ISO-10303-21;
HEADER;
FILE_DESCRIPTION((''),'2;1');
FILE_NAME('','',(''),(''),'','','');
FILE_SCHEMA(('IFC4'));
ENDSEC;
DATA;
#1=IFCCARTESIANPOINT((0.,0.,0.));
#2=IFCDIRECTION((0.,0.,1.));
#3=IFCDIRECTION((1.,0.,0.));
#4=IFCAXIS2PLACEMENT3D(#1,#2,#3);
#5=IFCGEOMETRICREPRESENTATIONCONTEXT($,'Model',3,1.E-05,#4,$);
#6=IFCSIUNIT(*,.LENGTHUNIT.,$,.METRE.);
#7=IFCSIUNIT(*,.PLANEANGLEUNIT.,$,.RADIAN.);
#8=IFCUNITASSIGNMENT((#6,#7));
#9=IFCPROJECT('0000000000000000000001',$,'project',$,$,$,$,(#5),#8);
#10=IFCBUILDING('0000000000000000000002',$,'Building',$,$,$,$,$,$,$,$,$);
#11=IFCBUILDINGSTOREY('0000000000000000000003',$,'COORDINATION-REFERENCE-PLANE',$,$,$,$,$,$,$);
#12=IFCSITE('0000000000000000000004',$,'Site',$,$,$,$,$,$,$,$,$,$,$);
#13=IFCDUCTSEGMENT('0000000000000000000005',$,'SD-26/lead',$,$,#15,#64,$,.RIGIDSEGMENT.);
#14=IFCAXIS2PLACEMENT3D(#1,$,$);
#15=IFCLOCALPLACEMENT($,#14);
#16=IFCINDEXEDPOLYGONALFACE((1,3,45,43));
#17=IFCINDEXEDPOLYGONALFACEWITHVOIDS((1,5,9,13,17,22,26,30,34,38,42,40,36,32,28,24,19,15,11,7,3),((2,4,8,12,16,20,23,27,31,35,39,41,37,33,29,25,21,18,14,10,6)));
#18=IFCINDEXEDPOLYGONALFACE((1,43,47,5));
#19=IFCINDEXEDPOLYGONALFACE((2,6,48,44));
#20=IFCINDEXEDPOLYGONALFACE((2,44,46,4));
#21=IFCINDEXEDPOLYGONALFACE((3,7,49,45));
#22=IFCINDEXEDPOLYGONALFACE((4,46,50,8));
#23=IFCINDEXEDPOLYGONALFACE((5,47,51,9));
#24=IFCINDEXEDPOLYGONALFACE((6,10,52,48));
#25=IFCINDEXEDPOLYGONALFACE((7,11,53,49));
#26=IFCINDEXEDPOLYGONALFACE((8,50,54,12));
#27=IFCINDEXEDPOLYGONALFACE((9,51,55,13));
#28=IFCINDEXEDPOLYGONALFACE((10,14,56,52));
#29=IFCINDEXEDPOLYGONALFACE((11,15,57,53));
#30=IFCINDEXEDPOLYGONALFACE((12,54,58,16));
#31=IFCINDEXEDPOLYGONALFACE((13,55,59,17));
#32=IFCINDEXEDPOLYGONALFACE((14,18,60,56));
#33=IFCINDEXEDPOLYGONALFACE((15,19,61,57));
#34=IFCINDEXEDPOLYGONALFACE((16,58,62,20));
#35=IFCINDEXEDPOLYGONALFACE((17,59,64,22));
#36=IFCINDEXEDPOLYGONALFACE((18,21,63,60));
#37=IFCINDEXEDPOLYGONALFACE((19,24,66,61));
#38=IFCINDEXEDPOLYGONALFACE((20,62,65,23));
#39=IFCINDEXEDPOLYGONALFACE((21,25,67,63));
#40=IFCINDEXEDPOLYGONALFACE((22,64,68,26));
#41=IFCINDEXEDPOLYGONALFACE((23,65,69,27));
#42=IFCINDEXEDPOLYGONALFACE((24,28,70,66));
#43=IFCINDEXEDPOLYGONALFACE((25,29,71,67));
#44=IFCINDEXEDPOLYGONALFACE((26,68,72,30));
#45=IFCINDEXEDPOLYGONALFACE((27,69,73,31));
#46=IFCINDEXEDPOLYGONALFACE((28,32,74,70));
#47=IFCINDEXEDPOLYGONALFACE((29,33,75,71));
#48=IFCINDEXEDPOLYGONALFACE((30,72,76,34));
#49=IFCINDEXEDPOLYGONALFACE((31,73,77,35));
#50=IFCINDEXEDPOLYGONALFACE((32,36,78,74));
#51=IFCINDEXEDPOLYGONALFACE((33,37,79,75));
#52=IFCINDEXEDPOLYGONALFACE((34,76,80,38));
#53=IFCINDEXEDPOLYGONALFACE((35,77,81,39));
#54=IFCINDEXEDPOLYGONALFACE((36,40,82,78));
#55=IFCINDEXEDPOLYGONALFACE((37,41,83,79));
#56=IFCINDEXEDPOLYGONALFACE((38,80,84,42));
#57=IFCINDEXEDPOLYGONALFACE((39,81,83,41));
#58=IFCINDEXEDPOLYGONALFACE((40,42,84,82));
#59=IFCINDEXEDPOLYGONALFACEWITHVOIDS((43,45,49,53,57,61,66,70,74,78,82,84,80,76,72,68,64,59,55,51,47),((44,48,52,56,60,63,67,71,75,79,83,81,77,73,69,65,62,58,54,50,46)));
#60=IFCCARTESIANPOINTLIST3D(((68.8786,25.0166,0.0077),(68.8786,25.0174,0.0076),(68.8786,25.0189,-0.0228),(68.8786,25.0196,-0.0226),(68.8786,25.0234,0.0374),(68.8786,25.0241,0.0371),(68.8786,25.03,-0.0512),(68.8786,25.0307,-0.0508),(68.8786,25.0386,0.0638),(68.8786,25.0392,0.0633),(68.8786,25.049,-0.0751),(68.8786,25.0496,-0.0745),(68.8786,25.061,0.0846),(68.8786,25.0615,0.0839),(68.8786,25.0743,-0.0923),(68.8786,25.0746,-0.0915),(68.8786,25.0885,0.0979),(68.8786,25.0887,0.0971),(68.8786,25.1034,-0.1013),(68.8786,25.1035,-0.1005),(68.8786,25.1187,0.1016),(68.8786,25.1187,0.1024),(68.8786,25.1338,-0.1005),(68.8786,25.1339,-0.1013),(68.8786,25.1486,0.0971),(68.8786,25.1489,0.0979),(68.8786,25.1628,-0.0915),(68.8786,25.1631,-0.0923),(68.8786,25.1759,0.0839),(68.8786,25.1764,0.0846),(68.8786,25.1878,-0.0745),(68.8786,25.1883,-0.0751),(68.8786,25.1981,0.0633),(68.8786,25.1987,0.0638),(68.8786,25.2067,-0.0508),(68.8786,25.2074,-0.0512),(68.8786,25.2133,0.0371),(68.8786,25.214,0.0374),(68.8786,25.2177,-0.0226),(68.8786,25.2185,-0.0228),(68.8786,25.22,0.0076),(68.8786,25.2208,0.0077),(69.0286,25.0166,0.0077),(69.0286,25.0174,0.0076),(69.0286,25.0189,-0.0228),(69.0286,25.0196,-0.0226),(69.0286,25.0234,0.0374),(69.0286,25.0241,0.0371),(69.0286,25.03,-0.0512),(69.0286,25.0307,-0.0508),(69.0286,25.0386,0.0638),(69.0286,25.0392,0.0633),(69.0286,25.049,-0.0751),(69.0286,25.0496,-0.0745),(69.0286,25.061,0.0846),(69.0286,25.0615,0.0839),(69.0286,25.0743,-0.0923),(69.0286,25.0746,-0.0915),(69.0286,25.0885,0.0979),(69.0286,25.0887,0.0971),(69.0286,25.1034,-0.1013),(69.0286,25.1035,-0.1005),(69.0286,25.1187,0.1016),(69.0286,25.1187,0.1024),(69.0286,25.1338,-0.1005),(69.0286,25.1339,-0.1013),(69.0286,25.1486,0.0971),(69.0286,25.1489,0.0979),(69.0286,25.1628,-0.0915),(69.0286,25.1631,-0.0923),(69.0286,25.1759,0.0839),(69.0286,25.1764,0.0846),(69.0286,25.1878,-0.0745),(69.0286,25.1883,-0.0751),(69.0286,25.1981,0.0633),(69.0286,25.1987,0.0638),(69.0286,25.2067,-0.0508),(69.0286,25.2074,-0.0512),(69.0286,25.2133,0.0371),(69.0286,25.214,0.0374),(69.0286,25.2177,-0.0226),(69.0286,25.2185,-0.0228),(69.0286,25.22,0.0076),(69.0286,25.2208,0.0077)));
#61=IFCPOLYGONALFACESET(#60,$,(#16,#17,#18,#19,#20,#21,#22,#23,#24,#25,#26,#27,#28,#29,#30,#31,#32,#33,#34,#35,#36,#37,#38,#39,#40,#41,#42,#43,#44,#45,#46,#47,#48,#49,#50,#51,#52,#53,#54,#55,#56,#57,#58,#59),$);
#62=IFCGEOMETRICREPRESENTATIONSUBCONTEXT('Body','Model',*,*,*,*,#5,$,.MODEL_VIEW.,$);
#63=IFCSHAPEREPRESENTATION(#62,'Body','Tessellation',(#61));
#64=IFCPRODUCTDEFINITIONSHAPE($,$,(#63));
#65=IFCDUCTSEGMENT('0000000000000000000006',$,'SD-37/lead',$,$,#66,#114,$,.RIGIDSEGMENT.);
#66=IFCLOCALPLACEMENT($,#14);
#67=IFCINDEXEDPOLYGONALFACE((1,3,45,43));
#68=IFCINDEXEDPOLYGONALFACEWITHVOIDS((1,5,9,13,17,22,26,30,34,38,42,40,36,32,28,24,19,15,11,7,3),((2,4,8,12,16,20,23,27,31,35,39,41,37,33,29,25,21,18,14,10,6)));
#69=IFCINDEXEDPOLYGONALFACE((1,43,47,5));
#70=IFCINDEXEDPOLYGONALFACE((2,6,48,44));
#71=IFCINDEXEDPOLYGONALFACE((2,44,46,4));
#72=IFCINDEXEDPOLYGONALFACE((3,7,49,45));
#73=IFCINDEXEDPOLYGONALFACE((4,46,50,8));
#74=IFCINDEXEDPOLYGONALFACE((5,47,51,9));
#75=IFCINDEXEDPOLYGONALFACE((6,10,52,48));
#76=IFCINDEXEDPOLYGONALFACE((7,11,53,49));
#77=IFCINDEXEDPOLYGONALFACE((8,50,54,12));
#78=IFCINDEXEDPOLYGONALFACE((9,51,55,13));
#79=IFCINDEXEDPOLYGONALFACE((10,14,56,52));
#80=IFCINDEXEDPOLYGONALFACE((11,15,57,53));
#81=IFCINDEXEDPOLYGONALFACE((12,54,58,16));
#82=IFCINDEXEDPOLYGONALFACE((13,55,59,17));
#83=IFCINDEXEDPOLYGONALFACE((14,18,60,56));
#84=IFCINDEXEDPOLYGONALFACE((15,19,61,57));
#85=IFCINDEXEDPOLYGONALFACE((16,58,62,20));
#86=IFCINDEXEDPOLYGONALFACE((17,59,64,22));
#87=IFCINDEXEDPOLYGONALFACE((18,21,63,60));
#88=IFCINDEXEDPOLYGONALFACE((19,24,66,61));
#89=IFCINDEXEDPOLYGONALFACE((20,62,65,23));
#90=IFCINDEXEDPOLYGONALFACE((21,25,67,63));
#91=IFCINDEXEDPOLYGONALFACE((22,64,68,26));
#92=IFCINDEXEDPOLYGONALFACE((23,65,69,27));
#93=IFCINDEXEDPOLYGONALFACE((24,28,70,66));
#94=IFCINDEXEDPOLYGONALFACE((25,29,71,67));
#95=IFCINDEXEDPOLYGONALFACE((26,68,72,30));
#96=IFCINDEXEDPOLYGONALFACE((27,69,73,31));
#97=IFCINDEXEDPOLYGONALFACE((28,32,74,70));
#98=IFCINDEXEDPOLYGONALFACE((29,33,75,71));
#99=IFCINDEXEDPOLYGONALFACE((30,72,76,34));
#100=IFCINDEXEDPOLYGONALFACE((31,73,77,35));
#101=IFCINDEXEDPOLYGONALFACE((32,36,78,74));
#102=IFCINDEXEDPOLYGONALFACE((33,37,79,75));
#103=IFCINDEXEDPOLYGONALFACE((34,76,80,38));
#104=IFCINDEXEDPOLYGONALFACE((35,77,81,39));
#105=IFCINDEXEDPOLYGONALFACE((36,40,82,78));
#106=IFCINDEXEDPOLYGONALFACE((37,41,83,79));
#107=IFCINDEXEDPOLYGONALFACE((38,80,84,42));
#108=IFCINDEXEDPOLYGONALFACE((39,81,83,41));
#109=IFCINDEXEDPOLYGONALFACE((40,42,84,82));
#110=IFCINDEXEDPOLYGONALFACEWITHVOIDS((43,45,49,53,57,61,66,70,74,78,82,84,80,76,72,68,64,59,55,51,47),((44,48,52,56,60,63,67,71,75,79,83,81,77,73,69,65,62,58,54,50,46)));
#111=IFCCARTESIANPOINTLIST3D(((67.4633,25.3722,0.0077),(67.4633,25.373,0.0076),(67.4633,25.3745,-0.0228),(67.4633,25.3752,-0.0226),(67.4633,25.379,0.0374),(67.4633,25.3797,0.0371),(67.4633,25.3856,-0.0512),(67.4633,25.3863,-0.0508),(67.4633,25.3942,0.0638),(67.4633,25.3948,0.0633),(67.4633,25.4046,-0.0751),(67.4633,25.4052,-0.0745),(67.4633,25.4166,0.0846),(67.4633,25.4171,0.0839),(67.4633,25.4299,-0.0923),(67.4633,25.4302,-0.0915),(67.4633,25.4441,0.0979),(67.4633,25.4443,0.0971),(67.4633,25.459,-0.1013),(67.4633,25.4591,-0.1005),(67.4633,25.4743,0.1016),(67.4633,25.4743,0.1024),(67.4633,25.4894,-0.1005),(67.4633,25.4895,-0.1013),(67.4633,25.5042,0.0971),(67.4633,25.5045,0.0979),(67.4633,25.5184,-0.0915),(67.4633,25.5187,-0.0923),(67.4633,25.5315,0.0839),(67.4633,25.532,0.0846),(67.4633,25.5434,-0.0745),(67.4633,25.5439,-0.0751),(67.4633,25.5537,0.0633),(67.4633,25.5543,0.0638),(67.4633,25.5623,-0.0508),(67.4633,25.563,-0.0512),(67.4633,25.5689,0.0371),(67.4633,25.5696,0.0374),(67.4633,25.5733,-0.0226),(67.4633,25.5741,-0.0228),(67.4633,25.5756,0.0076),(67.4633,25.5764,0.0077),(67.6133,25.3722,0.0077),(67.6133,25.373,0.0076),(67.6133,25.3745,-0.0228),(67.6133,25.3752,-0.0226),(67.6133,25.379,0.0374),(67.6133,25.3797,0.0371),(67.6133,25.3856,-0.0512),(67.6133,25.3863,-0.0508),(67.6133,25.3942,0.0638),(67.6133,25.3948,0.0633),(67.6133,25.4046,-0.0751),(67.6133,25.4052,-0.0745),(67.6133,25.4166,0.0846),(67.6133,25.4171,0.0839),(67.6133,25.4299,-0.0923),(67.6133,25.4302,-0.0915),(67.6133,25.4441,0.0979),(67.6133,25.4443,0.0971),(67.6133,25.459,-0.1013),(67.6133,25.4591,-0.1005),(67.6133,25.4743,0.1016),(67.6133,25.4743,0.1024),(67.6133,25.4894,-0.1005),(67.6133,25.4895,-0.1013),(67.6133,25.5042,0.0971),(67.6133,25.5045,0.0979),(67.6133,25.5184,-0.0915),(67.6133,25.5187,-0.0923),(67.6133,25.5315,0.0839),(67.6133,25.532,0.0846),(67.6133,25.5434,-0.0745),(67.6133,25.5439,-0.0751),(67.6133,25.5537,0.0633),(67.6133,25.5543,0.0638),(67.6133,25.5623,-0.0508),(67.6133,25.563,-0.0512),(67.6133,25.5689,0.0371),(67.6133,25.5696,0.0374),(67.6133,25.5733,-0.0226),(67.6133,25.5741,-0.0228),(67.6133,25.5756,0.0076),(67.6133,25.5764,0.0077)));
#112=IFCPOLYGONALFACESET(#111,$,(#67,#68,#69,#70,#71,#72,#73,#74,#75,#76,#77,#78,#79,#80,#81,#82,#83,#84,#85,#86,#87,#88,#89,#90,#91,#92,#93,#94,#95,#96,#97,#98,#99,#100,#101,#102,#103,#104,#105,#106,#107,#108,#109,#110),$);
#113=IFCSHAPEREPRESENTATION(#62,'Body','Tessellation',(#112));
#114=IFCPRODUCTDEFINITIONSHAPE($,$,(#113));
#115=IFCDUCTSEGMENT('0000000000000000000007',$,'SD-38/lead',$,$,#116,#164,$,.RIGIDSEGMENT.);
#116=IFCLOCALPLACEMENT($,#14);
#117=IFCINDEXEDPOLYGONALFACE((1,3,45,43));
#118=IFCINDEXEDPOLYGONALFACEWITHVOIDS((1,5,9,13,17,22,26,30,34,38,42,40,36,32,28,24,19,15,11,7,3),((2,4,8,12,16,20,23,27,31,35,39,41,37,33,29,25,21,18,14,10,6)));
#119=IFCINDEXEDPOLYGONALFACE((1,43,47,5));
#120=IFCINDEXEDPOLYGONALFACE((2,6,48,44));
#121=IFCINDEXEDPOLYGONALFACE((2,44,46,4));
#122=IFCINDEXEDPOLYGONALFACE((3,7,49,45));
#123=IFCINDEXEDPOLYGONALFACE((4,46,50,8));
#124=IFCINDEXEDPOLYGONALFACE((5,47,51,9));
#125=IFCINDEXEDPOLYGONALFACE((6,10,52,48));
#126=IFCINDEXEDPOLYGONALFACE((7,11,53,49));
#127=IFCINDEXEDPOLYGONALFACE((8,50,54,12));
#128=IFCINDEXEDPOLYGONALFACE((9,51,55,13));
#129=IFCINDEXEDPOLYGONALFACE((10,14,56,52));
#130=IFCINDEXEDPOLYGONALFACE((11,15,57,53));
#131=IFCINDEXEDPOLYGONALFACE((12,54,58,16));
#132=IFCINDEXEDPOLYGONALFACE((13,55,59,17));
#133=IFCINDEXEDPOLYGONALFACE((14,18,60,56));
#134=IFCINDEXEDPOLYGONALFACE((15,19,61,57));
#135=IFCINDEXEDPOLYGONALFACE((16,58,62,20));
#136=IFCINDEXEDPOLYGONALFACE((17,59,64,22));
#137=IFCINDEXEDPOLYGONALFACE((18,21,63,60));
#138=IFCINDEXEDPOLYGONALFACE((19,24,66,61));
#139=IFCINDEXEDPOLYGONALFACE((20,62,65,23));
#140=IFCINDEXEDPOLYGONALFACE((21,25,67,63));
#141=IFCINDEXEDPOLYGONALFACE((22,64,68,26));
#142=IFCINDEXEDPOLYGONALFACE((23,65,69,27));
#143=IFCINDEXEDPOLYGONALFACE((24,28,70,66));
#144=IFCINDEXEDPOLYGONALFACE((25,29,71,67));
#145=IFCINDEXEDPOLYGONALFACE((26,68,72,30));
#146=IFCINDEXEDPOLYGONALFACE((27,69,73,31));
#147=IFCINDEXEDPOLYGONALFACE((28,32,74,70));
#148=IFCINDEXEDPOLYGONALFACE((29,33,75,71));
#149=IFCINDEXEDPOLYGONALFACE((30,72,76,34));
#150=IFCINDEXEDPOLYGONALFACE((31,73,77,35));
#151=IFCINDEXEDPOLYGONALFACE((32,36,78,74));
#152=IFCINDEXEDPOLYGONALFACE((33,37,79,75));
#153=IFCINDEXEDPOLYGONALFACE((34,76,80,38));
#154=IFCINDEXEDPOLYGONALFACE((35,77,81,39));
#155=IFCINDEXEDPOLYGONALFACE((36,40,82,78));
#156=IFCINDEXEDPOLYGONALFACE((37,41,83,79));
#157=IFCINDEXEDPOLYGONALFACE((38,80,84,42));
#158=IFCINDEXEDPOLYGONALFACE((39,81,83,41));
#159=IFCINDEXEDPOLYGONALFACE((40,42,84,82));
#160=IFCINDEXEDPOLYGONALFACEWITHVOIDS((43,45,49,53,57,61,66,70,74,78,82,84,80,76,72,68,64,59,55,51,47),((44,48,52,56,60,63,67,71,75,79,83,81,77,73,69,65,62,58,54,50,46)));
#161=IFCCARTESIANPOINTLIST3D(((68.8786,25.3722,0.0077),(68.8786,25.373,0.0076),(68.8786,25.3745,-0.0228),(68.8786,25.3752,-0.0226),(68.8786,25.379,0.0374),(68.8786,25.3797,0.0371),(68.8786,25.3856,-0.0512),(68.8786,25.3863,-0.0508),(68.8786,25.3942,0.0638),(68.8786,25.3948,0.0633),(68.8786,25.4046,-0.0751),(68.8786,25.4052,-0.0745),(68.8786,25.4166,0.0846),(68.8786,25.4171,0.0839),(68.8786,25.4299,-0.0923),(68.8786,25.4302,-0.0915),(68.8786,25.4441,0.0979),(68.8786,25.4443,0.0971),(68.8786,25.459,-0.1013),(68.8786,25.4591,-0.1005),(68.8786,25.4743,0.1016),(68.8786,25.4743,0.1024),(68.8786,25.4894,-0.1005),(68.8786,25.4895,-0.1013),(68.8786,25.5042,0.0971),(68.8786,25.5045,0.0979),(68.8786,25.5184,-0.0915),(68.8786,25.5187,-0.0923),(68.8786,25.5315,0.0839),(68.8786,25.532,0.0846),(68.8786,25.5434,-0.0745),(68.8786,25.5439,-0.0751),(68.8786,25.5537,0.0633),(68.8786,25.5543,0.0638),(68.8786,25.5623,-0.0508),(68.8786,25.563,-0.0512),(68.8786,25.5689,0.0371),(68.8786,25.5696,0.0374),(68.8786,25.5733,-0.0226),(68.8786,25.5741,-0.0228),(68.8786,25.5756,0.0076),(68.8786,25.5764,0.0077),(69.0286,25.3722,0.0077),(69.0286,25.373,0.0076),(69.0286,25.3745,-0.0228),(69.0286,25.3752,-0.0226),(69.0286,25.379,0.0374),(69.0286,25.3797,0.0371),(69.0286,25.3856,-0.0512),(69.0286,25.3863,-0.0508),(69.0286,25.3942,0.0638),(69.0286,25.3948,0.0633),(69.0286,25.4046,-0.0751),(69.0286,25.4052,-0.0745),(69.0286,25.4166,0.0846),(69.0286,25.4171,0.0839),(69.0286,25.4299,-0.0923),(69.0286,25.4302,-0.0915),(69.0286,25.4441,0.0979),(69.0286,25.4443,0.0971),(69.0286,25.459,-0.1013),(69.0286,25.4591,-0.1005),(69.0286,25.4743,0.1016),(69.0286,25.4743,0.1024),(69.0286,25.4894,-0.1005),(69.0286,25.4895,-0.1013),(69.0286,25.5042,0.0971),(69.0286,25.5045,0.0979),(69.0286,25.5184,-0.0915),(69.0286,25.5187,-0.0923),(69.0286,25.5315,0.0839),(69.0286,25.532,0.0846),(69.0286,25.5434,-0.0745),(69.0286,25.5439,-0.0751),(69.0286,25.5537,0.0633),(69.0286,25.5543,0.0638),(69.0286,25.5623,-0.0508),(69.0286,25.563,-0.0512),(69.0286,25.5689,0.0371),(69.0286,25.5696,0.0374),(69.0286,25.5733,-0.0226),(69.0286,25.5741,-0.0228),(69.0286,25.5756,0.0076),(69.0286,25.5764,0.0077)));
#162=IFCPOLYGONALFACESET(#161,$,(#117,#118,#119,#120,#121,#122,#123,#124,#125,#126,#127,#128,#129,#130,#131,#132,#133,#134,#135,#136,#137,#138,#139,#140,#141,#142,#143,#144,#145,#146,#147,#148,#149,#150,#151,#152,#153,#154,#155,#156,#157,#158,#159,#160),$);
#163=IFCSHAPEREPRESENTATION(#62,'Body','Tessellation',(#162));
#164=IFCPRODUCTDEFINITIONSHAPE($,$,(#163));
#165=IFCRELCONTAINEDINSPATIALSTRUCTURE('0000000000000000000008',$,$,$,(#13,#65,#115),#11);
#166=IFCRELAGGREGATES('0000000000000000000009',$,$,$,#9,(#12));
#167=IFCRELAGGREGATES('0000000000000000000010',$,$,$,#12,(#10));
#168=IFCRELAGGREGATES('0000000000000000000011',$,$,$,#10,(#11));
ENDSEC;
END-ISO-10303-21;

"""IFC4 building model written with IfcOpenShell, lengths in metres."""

from ifc_helpers import new_model, si_unit, frame, origin_with_axes, place, context, subcontext, project, spatial, hollow_circle, extrude, element, save


model = new_model("IFC4")

# Units and contexts
model_context = context("Model", 3, precision=1e-05, world=origin_with_axes())
body_context_1 = subcontext(model_context, "Body", "Model", "MODEL_VIEW")
ifc_project = project(units=[si_unit("LENGTHUNIT", "METRE"), si_unit("PLANEANGLEUNIT", "RADIAN")], contexts=[model_context])

# Site, building, storey
site = spatial("IfcSite", under=ifc_project, Name="Site")
building = spatial("IfcBuilding", under=site, Name="Building")
storey = spatial("IfcBuildingStorey", under=building, Name="COORDINATION-REFERENCE-PLANE")

# Duct segments
for number, where, z_axis, x_axis, name in (
    (1, (68.8786, 25.1187, 0.0), (1.0, 0.0, 0.0), (0.0, 0.0, 1.0), "SD-26/lead"),
    (2, (67.6133, 25.4743, 0.0), (-1.0, 0.0, 0.0), (0.0, 0.0, 1.0), "SD-37/lead"),
    (3, (68.8786, 25.4743, 0.0), (1.0, 0.0, 0.0), (0.0, 0.0, 1.0), "SD-38/lead"),
):
    element("IfcDuctSegment", number, at=place(None, frame(where, z_axis=z_axis, x_axis=x_axis)), inside=storey, Name=name, PredefinedType="RIGIDSEGMENT", context=body_context_1, shape_type="SweptSolid", body=[
        extrude(hollow_circle(Radius=0.1024, WallThickness=0.0008), origin_with_axes(), (0.0, 0.0, 1.0), 0.15),
    ])

save(model, "model.ifc")
